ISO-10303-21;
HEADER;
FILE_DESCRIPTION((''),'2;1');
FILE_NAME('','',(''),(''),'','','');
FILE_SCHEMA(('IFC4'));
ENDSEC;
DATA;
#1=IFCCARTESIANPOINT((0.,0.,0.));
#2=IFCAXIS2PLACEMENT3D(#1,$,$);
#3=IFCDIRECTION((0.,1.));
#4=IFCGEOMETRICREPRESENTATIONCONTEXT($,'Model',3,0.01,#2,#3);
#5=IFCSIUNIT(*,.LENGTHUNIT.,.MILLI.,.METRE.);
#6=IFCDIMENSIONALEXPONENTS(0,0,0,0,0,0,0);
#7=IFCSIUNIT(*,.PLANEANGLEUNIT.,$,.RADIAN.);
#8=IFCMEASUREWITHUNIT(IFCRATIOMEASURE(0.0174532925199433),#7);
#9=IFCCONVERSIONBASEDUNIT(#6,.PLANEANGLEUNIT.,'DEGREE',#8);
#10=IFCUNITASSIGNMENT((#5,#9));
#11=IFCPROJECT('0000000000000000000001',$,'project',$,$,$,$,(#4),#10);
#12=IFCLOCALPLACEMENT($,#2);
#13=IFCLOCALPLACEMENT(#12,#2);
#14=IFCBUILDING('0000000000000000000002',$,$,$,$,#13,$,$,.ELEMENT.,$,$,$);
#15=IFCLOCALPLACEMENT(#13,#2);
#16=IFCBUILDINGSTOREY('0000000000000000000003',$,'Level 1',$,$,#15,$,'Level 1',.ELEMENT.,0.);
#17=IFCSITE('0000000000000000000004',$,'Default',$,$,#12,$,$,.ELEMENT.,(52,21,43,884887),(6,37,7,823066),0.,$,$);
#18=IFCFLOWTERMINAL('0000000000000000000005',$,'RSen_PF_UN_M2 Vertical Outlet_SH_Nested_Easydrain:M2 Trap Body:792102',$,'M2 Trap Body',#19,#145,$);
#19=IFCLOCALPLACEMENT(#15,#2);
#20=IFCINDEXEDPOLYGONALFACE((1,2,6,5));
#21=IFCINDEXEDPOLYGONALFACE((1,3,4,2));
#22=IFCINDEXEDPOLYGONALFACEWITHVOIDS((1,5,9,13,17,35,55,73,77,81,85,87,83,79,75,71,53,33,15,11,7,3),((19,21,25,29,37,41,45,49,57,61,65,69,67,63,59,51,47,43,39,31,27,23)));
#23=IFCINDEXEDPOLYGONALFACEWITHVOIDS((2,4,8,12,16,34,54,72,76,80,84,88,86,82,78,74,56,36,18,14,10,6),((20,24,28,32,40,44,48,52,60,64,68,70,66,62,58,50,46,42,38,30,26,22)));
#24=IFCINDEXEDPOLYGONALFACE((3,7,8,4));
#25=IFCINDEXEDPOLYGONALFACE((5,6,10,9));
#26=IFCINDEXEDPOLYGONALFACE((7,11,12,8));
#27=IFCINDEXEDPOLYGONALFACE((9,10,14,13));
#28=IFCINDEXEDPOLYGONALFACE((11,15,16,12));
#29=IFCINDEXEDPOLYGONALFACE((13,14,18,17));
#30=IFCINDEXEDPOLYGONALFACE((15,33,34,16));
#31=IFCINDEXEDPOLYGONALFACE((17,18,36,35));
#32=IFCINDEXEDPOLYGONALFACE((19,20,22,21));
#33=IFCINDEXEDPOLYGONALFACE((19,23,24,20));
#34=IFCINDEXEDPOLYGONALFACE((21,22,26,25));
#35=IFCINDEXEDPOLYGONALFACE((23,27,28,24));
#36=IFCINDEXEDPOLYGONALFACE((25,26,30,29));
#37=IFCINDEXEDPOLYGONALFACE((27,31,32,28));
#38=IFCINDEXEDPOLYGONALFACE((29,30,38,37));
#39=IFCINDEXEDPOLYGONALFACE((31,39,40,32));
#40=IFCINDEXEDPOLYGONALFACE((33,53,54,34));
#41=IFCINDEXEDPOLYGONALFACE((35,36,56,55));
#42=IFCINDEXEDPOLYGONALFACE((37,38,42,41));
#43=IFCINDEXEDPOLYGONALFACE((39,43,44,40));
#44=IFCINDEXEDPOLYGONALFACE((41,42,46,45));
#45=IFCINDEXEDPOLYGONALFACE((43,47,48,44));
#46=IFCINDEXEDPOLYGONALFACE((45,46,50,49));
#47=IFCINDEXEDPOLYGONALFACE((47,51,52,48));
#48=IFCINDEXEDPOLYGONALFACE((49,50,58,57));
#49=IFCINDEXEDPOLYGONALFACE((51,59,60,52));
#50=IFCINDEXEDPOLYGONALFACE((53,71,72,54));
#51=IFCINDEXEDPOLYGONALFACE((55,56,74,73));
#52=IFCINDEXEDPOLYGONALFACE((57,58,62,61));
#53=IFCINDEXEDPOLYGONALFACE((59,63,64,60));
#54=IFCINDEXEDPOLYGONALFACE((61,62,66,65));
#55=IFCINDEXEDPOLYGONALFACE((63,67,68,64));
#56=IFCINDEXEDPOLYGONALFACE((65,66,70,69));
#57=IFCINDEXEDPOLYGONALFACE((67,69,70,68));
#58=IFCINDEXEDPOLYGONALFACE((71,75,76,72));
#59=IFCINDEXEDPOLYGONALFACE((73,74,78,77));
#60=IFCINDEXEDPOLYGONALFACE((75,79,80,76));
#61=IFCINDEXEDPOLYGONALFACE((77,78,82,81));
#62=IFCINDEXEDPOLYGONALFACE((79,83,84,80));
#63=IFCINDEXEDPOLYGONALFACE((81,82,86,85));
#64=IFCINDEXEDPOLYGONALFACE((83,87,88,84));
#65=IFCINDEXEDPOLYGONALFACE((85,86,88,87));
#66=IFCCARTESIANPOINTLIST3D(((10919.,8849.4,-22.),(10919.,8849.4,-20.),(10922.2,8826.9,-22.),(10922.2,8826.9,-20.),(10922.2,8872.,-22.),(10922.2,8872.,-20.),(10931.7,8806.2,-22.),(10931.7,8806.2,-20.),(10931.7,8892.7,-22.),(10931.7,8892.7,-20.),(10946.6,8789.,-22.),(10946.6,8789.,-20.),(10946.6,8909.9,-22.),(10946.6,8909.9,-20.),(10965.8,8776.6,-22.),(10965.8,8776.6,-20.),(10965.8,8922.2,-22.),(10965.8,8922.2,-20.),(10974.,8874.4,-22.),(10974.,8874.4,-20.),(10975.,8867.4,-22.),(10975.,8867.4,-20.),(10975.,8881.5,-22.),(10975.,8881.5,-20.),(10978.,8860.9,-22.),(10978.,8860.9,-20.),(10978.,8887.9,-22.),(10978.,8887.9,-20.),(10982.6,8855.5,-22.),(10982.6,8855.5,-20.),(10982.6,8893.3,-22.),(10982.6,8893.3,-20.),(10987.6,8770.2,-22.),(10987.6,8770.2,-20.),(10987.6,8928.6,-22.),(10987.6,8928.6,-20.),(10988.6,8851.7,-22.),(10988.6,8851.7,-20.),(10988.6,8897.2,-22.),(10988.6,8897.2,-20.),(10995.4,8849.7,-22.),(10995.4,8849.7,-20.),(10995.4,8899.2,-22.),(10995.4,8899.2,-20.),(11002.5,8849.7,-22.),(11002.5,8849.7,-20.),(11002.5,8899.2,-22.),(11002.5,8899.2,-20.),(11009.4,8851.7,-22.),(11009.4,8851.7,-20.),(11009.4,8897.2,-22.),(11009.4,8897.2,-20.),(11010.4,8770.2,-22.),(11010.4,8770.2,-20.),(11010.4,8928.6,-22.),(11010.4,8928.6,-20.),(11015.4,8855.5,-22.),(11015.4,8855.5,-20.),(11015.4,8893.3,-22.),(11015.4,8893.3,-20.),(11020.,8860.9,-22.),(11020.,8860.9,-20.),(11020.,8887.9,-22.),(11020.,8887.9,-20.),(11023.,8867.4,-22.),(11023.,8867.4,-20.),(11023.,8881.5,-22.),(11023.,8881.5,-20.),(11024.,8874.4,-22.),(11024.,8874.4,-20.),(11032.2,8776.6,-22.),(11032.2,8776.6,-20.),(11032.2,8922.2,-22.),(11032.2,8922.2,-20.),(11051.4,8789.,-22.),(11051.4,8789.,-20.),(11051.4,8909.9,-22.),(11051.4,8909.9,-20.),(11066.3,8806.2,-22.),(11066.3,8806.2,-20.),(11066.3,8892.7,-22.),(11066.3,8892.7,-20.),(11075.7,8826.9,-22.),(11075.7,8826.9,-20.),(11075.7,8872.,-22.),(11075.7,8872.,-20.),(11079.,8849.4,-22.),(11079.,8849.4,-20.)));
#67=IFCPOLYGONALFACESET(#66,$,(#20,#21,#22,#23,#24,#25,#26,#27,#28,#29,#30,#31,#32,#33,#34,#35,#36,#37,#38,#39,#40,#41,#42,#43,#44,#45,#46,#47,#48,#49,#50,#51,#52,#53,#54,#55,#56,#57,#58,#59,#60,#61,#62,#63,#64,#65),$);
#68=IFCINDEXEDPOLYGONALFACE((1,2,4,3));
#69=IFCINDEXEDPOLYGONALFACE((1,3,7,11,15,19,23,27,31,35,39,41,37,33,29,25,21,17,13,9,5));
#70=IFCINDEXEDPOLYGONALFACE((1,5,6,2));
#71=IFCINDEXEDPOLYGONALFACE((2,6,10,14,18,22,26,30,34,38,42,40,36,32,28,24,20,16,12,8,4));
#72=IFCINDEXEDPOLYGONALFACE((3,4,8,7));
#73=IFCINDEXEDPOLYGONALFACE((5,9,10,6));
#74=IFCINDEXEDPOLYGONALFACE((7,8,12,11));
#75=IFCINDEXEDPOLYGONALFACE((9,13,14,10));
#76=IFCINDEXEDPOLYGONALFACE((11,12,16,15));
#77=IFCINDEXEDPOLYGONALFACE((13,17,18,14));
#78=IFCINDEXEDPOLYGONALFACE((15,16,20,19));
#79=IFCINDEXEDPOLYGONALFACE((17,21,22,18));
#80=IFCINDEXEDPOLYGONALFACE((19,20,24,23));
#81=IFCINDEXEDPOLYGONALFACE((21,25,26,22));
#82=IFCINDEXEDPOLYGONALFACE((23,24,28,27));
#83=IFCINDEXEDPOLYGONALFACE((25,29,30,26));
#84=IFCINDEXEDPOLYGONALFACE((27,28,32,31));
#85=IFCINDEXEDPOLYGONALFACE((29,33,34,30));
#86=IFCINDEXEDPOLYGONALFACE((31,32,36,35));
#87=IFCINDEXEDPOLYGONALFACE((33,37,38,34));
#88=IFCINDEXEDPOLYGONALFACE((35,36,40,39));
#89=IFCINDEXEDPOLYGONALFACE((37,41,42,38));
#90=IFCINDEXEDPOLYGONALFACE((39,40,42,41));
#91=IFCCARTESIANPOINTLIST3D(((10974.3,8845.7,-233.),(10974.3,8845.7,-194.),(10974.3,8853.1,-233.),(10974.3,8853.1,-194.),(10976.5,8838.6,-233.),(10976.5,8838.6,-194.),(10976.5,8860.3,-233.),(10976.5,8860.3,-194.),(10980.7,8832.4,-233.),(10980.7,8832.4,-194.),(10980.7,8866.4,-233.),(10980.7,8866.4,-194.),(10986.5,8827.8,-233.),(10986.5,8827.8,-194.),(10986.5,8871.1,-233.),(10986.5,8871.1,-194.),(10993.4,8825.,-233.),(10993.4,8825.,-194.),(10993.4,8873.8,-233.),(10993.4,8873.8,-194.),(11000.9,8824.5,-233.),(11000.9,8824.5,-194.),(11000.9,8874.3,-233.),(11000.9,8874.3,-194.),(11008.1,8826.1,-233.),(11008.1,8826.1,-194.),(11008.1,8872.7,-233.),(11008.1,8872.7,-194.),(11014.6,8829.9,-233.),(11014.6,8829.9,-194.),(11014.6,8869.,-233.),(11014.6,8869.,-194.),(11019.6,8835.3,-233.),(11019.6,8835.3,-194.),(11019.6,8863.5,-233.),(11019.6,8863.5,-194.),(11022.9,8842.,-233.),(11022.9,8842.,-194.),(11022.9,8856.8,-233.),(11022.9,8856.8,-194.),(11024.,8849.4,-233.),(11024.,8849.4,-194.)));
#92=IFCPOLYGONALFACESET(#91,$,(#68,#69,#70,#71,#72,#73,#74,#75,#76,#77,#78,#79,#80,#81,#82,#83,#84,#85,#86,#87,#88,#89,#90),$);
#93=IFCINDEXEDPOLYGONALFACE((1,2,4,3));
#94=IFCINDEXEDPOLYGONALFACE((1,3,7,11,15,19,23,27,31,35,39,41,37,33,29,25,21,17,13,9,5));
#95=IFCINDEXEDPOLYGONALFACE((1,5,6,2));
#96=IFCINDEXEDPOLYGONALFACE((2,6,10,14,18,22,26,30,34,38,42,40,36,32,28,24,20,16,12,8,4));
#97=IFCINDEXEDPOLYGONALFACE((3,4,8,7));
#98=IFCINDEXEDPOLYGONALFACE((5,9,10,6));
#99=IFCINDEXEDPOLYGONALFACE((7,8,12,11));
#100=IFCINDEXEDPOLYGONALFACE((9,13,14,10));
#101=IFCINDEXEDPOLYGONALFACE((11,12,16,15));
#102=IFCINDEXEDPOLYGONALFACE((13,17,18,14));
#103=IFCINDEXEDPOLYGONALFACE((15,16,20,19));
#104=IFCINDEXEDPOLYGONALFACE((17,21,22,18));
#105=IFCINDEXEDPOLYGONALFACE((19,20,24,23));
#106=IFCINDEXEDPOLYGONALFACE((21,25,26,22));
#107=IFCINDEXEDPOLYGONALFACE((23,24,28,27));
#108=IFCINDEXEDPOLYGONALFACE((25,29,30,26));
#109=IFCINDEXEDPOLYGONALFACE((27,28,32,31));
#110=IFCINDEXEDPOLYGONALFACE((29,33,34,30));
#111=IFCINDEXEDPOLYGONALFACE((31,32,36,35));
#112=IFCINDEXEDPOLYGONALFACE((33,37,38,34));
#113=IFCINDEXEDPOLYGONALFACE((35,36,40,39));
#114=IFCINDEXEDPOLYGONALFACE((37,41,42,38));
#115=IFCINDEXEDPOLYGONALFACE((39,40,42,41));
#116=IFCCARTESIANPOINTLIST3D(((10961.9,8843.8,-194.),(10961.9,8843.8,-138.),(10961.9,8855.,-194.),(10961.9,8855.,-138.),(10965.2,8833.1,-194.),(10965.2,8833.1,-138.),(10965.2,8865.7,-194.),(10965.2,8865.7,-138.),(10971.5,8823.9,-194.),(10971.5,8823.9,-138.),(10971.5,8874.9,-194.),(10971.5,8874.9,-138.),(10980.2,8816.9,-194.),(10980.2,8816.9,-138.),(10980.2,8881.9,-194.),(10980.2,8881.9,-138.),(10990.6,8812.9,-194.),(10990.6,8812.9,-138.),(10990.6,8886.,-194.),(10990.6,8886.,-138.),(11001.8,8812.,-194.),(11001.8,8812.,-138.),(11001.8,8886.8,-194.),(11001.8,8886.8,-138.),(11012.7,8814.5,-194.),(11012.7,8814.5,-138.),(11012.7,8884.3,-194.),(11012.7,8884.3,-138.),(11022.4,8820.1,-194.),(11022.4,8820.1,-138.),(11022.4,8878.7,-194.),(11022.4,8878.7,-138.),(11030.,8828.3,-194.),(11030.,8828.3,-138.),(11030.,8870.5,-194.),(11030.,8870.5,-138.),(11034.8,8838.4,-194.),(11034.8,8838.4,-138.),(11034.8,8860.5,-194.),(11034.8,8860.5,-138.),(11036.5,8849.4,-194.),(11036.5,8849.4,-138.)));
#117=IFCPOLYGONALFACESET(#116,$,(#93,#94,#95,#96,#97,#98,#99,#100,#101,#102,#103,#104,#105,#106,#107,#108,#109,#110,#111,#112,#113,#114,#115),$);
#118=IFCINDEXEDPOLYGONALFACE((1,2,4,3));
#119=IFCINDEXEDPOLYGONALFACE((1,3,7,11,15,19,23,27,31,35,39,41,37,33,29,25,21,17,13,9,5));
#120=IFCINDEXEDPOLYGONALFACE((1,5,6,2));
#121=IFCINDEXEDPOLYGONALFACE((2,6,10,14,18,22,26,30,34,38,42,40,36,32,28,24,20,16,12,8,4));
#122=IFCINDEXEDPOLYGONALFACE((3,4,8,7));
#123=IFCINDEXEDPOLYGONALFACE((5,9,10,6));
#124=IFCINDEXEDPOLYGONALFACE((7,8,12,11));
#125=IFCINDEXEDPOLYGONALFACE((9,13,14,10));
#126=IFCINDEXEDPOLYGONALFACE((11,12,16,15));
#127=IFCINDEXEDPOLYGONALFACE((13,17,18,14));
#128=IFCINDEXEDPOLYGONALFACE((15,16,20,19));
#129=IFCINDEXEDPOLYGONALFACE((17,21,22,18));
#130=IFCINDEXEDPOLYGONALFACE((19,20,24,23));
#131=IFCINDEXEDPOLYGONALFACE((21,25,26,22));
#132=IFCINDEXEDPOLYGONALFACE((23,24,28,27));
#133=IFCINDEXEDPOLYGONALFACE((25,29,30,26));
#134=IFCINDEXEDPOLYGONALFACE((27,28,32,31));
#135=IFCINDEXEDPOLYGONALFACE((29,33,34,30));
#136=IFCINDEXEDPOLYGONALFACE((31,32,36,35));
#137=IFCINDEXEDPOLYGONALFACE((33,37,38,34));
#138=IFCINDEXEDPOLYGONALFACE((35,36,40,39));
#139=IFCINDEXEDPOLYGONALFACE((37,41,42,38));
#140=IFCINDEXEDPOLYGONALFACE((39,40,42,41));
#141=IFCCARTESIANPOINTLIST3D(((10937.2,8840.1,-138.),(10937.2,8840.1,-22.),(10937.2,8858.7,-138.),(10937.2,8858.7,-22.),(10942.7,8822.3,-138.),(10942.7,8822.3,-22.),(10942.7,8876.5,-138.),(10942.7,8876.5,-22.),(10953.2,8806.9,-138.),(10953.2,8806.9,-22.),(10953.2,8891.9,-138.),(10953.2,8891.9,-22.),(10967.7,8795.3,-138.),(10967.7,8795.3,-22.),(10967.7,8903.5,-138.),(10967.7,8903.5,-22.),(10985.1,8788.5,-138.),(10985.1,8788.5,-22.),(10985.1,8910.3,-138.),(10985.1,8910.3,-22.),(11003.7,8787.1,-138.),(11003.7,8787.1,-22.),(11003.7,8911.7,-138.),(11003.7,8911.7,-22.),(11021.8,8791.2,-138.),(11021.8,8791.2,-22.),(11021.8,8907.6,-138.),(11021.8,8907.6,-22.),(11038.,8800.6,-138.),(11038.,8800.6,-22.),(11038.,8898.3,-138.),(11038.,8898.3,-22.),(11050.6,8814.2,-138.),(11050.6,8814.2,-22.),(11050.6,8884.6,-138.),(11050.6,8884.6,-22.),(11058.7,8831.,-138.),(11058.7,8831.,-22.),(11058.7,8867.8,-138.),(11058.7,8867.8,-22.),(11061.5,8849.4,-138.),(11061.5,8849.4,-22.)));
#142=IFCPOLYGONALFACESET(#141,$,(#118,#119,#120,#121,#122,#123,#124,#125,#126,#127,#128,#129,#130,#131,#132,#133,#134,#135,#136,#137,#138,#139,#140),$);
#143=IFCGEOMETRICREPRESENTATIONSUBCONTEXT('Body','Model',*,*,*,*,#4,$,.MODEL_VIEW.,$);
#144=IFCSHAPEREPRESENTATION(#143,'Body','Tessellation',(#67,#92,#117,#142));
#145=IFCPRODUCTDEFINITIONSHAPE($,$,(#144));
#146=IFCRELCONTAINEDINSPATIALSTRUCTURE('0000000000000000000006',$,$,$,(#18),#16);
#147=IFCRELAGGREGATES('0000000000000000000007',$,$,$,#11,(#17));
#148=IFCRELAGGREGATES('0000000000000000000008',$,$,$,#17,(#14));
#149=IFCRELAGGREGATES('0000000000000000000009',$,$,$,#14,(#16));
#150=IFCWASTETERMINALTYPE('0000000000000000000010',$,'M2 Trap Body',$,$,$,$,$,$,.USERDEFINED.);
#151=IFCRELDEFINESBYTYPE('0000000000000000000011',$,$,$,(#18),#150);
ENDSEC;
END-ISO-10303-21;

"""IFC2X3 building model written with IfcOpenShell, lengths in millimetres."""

from ifc_helpers import new_model, entity, si_unit, converted_unit, direction, frame, frame_2d, origin, origin_2d_with_axis, place, context, subcontext, project, spatial, circle_curve, parameter, trimmed, segment, composite_curve, circle, outline, extrude, source, transform, mapped, type_object, type_shapes, element, save


model = new_model("IFC2X3")

# Units and contexts
model_context = context("Model", 3, precision=0.01, world=origin(), true_north=direction((0.0, 1.0)))
body_context = subcontext(model_context, "Body", "Model", "MODEL_VIEW")
ifc_project = project(units=[si_unit("LENGTHUNIT", "METRE", prefix="MILLI"), converted_unit("PLANEANGLEUNIT", "DEGREE", entity("IfcRatioMeasure", 0.0174532925199433), si_unit("PLANEANGLEUNIT", "RADIAN"), dimensions=[0, 0, 0, 0, 0, 0, 0])], contexts=[model_context])

# Site, building, storey
site_placement = place(None, origin())
site = spatial("IfcSite", under=ifc_project, at=site_placement, Name="Default", CompositionType="ELEMENT", RefLatitude=(52, 21, 43, 884887), RefLongitude=(6, 37, 7, 823066), RefElevation=0.0)
building_placement = place(site_placement, origin())
building = spatial("IfcBuilding", under=site, at=building_placement, CompositionType="ELEMENT")
storey_placement = place(building_placement, origin())
storey = spatial("IfcBuildingStorey", under=building, at=storey_placement, Name="Level 1", LongName="Level 1", CompositionType="ELEMENT", Elevation=0.0)

# Flow terminal
waste_terminal_type_1 = type_object("IfcWasteTerminalType", Name="M2 Trap Body", PredefinedType="USERDEFINED")
shared_shape_1 = source(origin(), body_context, "Body", "SweptSolid", [
    extrude(outline(composite_curve([segment(trimmed(circle_curve(origin_2d_with_axis(), 80.0), [parameter(0.0)], [parameter(180.0)], True, "PARAMETER"), True, "CONTINUOUS"), segment(trimmed(circle_curve(origin_2d_with_axis(), 80.0), [parameter(180.0)], [parameter(360.0)], True, "PARAMETER"), True, "CONTINUOUS")], self_intersect=False), holes=[composite_curve([segment(trimmed(circle_curve(frame_2d((0.0, 25.0), x_axis=(1.0, 0.0)), 25.0), [parameter(180.0)], [parameter(360.0)], True, "PARAMETER"), False, "CONTINUOUS"), segment(trimmed(circle_curve(frame_2d((0.0, 25.0), x_axis=(1.0, 0.0)), 25.0), [parameter(0.0)], [parameter(180.0)], True, "PARAMETER"), False, "CONTINUOUS")], self_intersect=False)]), frame((0.0, -25.0, -2.0)), (0.0, 0.0, 1.0), 2.0),
    extrude(circle(Radius=25.0, at=frame_2d((0.0, 0.0), x_axis=(1.0, 0.0))), frame((0.0, -25.0, -213.0)), (0.0, 0.0, 1.0), 39.0),
    extrude(circle(Radius=37.5, at=frame_2d((0.0, 0.0), x_axis=(1.0, 0.0))), frame((0.0, -25.0, -174.0)), (0.0, 0.0, 1.0), 56.0),
    extrude(circle(Radius=62.5, at=frame_2d((0.0, 0.0), x_axis=(1.0, 0.0))), frame((0.0, -25.0, -118.0)), (0.0, 0.0, 1.0), 116.0),
])
type_shapes(waste_terminal_type_1, [shared_shape_1])
flow_terminal_1_placement = place(storey_placement, frame((10999.0, 8874.4, -20.0)))
element("IfcFlowTerminal", 1, at=flow_terminal_1_placement, inside=storey, type_object=waste_terminal_type_1, Name="RSen_PF_UN_M2 Vertical Outlet_SH_Nested_Easydrain:M2 Trap Body:792102", ObjectType="M2 Trap Body", context=body_context, shape_type="MappedRepresentation", body=[
    mapped(shared_shape_1, transform((0.0, 0.0, 0.0), scale=1.0)),
])

save(model, "model.ifc")
